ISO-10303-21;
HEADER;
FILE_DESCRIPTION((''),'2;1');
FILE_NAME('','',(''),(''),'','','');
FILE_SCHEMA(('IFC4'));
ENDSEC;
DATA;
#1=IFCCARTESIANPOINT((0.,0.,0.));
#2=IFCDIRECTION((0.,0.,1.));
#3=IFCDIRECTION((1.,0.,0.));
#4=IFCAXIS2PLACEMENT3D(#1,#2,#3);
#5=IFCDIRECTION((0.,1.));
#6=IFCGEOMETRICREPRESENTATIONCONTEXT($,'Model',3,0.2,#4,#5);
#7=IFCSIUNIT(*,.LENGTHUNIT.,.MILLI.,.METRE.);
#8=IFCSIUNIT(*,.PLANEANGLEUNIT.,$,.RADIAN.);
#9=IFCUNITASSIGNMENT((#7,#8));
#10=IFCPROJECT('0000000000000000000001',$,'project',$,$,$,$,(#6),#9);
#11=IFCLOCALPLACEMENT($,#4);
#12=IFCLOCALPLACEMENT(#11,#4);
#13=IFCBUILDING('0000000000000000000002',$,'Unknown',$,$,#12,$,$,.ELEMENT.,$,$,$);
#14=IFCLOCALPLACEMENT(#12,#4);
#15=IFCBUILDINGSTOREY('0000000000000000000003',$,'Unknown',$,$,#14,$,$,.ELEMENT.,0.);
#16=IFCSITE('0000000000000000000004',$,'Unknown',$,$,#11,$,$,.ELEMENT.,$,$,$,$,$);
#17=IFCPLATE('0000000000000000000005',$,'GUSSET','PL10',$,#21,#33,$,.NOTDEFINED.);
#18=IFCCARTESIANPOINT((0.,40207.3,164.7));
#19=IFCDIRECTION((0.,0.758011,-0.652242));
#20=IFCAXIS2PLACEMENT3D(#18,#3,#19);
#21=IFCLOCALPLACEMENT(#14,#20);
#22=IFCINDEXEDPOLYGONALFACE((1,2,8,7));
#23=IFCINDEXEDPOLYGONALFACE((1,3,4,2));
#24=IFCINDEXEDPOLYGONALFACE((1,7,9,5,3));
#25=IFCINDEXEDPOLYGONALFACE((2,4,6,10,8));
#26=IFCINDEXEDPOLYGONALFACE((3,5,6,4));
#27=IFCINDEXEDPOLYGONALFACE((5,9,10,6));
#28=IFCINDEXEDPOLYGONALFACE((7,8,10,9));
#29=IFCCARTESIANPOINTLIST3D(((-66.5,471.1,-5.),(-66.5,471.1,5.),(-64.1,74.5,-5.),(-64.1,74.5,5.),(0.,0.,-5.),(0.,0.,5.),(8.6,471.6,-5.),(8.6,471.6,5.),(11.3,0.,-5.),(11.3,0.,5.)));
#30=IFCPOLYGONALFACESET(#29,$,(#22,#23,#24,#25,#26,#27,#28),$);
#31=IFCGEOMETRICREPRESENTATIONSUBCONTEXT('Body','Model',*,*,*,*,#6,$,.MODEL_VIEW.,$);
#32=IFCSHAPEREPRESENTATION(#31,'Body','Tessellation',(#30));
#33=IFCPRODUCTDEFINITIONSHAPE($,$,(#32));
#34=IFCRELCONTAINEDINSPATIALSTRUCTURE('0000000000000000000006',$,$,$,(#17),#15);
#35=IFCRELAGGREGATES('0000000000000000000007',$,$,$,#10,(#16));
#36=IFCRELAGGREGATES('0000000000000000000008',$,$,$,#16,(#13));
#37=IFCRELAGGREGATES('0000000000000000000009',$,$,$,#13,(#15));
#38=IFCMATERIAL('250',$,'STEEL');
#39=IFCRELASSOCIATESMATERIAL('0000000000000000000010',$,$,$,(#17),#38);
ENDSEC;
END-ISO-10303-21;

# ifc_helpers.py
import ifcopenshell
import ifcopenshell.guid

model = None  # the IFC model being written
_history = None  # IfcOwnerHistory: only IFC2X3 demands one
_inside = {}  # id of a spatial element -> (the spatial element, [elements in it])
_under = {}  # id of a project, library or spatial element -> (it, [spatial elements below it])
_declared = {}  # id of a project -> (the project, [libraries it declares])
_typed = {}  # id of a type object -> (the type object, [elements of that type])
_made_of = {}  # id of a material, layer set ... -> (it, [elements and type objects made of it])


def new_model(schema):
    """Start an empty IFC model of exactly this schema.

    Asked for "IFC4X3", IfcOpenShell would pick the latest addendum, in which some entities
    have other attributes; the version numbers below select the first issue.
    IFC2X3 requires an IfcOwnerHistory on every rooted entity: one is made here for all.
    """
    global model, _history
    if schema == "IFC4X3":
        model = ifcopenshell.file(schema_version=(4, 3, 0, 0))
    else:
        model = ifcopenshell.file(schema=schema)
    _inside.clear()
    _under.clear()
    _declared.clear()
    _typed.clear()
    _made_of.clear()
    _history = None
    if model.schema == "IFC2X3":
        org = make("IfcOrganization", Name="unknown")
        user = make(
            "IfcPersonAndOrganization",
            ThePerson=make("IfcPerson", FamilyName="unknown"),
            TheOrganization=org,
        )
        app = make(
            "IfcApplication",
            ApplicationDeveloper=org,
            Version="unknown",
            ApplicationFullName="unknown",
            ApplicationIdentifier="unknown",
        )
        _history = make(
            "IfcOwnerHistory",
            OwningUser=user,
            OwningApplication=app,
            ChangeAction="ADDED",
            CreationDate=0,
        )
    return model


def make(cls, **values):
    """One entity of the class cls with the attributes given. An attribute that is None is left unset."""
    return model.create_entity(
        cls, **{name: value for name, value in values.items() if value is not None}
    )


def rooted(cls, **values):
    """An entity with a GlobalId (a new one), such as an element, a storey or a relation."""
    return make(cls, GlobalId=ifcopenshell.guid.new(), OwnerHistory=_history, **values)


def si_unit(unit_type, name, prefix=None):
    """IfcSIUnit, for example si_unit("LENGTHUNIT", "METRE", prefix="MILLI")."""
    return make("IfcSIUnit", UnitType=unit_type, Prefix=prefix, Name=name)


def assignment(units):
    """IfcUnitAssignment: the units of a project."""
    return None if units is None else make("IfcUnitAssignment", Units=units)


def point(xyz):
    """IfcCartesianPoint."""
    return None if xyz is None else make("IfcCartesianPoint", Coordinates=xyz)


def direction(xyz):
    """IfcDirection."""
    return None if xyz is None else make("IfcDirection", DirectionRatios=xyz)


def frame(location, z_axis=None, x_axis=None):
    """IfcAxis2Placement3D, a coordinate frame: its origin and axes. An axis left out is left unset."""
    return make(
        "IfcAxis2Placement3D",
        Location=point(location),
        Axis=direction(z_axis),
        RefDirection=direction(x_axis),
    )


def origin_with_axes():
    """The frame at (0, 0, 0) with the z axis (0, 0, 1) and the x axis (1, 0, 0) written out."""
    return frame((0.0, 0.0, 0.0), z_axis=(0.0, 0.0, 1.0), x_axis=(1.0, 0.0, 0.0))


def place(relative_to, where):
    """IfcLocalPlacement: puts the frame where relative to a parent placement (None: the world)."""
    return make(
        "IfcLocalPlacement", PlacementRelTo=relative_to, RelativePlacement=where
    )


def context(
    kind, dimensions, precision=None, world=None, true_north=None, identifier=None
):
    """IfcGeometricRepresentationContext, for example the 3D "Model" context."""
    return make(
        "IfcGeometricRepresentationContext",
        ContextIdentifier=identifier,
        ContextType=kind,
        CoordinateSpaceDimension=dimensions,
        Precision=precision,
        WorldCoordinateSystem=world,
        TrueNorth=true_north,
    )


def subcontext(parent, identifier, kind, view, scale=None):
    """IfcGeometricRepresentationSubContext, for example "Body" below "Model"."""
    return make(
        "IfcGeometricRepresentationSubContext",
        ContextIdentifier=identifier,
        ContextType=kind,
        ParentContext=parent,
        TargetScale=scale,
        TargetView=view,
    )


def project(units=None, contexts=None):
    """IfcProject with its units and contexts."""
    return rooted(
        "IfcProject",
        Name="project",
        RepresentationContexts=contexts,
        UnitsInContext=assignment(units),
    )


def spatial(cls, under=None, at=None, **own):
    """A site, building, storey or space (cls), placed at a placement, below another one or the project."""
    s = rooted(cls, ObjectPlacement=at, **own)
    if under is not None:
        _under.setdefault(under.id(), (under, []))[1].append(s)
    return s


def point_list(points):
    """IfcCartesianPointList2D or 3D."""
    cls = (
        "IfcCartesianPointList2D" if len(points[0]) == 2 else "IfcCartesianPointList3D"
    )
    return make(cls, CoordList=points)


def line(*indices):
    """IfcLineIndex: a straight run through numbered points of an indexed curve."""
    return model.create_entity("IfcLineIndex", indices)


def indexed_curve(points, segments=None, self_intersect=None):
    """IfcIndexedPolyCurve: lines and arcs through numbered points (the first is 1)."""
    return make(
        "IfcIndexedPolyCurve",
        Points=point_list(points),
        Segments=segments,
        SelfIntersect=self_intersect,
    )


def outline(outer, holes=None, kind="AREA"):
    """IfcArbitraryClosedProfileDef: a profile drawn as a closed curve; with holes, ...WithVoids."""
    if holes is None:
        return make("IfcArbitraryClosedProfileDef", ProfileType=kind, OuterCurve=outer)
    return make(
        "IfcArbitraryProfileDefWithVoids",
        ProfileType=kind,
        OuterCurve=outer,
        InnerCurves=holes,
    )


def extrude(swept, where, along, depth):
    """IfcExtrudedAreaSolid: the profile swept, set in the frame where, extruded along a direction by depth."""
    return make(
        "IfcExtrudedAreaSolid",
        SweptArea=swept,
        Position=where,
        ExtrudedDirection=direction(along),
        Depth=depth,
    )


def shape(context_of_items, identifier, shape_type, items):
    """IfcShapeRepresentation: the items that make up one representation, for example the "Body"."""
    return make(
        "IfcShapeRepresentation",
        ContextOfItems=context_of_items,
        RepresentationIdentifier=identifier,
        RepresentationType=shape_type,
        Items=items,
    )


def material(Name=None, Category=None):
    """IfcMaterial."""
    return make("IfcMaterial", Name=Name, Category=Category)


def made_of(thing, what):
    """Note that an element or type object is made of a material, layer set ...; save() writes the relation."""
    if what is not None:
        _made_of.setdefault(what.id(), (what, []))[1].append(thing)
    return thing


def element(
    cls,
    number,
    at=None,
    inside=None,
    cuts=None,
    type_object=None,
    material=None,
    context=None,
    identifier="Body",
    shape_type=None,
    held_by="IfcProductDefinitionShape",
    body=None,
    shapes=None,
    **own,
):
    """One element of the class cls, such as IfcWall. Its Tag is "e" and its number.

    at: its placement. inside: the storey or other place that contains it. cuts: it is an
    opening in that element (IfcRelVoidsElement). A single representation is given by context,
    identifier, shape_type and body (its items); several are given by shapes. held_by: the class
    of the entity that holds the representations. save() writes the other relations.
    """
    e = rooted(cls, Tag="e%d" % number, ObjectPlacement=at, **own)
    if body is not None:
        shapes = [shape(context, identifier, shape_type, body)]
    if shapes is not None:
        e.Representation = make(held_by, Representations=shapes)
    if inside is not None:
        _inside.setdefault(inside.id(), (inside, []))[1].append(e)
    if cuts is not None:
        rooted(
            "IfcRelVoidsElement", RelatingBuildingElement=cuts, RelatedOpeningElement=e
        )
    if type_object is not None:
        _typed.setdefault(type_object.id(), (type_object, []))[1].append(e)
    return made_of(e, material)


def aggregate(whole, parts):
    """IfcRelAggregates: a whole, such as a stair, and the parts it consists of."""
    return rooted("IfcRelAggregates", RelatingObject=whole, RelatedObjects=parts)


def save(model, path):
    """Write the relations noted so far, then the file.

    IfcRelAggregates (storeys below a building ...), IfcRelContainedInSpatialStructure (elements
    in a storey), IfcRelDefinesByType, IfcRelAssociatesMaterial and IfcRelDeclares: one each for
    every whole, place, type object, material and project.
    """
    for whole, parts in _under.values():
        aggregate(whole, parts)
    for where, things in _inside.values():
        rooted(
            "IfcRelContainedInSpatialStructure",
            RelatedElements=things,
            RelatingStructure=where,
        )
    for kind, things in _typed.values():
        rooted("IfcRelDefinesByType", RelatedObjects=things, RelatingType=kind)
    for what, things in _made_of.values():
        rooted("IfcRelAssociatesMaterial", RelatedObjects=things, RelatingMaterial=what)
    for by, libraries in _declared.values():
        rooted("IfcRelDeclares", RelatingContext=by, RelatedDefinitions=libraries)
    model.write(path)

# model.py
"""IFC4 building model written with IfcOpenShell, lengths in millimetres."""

from ifc_helpers import new_model, si_unit, direction, frame, origin_with_axes, place, context, subcontext, project, spatial, line, indexed_curve, outline, extrude, material, element, save


model = new_model("IFC4")

# Units and contexts
model_context = context("Model", 3, precision=0.2, world=origin_with_axes(), true_north=direction((0.0, 1.0)))
body_context = subcontext(model_context, "Body", "Model", "MODEL_VIEW")
ifc_project = project(units=[si_unit("LENGTHUNIT", "METRE", prefix="MILLI"), si_unit("PLANEANGLEUNIT", "RADIAN")], contexts=[model_context])

# Site, building, storey
site_placement = place(None, origin_with_axes())
site = spatial("IfcSite", under=ifc_project, at=site_placement, Name="Unknown", CompositionType="ELEMENT")
building_placement = place(site_placement, origin_with_axes())
building = spatial("IfcBuilding", under=site, at=building_placement, Name="Unknown", CompositionType="ELEMENT")
storey_placement = place(building_placement, origin_with_axes())
storey = spatial("IfcBuildingStorey", under=building, at=storey_placement, Name="Unknown", CompositionType="ELEMENT", Elevation=0.0)

# Plate
ifc_material_1 = material(Name="250", Category="STEEL")
plate_1_placement = place(storey_placement, frame((0.0, 40207.3, 164.7), z_axis=(1.0, 0.0, 0.0), x_axis=(0.0, 0.758011, -0.652242)))
element("IfcPlate", 1, at=plate_1_placement, inside=storey, material=ifc_material_1, Name="GUSSET", Description="PL10", PredefinedType="NOTDEFINED", context=body_context, shape_type="SolidModel", body=[
    extrude(outline(indexed_curve([(0.0, 0.0), (11.3, 0.0), (8.6, 471.6), (-66.5, 471.1), (-64.1, 74.5)], segments=[line(1, 2, 3, 4, 5, 1)])), frame((0.0, 0.0, 5.0), z_axis=(0.0, 0.0, 1.0), x_axis=(1.0, 0.0, 0.0)), (0.0, 0.0, -1.0), 10.0),
])

save(model, "model.ifc")
